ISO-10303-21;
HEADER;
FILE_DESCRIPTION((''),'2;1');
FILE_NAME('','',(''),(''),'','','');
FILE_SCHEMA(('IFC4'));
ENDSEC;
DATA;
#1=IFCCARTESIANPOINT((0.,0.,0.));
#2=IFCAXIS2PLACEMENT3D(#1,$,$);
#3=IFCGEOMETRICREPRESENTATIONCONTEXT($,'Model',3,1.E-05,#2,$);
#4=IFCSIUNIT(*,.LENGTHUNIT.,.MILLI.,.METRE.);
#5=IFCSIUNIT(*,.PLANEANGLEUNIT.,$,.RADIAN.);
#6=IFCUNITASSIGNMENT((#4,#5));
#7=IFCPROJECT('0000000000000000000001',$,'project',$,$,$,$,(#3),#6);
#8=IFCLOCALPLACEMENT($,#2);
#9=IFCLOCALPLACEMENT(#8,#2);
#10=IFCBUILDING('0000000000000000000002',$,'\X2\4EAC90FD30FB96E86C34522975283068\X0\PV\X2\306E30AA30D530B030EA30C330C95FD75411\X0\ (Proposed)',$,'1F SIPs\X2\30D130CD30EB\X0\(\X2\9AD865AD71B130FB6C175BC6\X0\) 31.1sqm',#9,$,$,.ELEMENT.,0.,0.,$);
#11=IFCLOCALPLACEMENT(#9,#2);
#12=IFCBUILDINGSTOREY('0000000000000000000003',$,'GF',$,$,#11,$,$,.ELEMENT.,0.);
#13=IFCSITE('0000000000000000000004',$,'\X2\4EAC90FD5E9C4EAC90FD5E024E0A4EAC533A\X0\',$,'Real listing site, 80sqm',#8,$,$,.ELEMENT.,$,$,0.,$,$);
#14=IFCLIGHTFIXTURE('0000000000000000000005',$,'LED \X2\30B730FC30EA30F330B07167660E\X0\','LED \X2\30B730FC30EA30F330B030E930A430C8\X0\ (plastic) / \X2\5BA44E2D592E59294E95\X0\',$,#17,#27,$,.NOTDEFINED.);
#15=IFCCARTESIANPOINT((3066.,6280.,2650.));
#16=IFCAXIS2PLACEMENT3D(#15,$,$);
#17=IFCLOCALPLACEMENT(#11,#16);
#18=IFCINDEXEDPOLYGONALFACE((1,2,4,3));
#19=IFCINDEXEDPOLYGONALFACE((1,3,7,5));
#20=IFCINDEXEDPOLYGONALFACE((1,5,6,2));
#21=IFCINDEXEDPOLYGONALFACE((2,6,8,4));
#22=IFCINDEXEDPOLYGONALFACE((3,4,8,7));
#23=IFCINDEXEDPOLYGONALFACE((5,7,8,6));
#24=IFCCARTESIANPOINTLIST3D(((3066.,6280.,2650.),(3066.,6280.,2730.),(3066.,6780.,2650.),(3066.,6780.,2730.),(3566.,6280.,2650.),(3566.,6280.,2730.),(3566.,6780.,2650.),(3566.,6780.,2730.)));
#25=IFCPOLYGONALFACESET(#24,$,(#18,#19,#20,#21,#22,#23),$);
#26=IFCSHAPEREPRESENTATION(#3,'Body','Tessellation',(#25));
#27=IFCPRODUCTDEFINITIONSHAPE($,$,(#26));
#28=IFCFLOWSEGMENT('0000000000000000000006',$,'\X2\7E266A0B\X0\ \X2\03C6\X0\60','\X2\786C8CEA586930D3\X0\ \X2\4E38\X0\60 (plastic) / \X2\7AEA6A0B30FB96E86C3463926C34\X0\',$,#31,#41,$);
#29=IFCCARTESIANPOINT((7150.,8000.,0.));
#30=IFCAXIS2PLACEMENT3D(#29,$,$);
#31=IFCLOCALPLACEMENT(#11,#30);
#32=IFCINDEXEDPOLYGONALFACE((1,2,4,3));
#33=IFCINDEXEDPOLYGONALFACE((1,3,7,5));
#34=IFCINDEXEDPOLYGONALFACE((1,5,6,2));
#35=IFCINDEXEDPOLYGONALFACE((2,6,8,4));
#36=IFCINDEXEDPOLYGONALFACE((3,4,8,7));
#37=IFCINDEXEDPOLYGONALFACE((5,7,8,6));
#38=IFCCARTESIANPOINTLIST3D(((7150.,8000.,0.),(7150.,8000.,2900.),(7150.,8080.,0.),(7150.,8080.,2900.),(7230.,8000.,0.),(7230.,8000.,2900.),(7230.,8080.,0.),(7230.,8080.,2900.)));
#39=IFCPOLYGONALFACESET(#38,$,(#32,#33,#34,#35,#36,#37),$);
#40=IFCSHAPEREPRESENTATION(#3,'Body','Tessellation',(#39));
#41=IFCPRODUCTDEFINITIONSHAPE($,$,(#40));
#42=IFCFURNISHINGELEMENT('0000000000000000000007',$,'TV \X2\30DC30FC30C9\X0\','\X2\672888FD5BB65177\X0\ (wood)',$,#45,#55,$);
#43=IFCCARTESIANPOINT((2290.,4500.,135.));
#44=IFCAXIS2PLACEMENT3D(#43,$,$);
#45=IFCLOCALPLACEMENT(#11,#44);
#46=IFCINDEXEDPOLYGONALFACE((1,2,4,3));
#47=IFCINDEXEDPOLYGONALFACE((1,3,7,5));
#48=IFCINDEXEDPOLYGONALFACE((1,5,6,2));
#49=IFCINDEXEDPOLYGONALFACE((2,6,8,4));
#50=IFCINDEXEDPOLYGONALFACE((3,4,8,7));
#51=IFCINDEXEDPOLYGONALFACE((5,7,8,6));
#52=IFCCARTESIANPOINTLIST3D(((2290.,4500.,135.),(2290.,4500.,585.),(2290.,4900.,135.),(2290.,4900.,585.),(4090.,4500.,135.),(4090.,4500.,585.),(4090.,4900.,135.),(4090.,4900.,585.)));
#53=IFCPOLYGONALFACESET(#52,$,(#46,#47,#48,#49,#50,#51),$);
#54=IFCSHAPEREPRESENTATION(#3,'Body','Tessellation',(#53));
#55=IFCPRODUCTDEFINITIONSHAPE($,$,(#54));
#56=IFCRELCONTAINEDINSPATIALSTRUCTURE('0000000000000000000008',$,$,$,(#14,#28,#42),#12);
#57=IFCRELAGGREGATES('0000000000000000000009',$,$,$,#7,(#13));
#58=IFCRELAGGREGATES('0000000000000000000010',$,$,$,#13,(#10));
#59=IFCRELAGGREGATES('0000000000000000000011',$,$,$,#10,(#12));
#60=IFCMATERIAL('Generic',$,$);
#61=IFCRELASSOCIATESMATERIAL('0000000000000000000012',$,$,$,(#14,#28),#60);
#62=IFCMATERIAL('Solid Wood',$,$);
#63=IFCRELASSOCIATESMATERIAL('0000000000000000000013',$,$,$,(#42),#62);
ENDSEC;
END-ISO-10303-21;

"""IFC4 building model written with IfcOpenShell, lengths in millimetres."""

from ifc_helpers import new_model, si_unit, frame, frame_2d, origin, place, context, project, spatial, rectangle, extrude, material, element, save


model = new_model("IFC4")

# Units and contexts
model_context = context("Model", 3, precision=1e-05, world=origin())
ifc_project = project(units=[si_unit("LENGTHUNIT", "METRE", prefix="MILLI"), si_unit("PLANEANGLEUNIT", "RADIAN")], contexts=[model_context])

# Site, building, storey
site_placement = place(None, origin())
site = spatial("IfcSite", under=ifc_project, at=site_placement, Name="京都府京都市上京区", ObjectType="Real listing site, 80sqm", CompositionType="ELEMENT", RefElevation=0.0)
building_placement = place(site_placement, origin())
building = spatial("IfcBuilding", under=site, at=building_placement, Name="京都・雨水利用とPVのオフグリッド志向 (Proposed)", ObjectType="1F SIPsパネル(高断熱・気密) 31.1sqm", CompositionType="ELEMENT", ElevationOfRefHeight=0.0, ElevationOfTerrain=0.0)
storey_placement = place(building_placement, origin())
storey = spatial("IfcBuildingStorey", under=building, at=storey_placement, Name="GF", CompositionType="ELEMENT", Elevation=0.0)

# Shared definitions
ifc_material_1 = material(Name="Solid Wood")

# Shared definitions
ifc_material_2 = material(Name="Generic")

# Light fixture
light_fixture_1_placement = place(storey_placement, frame((3066.0, 6280.0, 2650.0)))
element("IfcLightFixture", 1, at=light_fixture_1_placement, inside=storey, material=ifc_material_2, Name="LED シーリング照明", Description="LED シーリングライト (plastic) / 室中央天井", PredefinedType="NOTDEFINED", context=model_context, shape_type="SweptSolid", body=[
    extrude(rectangle(XDim=500.0, YDim=500.0, at=frame_2d((250.0, 250.0))), frame((3066.0, 6280.0, 2650.0)), (0.0, 0.0, 1.0), 80.0),
])

# Flow segment
flow_segment_placement = place(storey_placement, frame((7150.0, 8000.0, 0.0)))
element("IfcFlowSegment", 2, at=flow_segment_placement, inside=storey, material=ifc_material_2, Name="縦樋 φ60", Description="硬質塩ビ 丸60 (plastic) / 竪樋・雨水排水", context=model_context, shape_type="SweptSolid", body=[
    extrude(rectangle(XDim=80.0, YDim=80.0, at=frame_2d((40.0, 40.0))), frame((7150.0, 8000.0, 0.0)), (0.0, 0.0, 1.0), 2900.0),
])

# Furnishing element
furnishing_placement = place(storey_placement, frame((2290.0, 4500.0, 135.0)))
element("IfcFurnishingElement", 3, at=furnishing_placement, inside=storey, material=ifc_material_1, Name="TV ボード", Description="木製家具 (wood)", context=model_context, shape_type="SweptSolid", body=[
    extrude(rectangle(XDim=1800.0, YDim=400.0, at=frame_2d((900.0, 200.0))), frame((2290.0, 4500.0, 135.0)), (0.0, 0.0, 1.0), 450.0),
])

save(model, "model.ifc")
